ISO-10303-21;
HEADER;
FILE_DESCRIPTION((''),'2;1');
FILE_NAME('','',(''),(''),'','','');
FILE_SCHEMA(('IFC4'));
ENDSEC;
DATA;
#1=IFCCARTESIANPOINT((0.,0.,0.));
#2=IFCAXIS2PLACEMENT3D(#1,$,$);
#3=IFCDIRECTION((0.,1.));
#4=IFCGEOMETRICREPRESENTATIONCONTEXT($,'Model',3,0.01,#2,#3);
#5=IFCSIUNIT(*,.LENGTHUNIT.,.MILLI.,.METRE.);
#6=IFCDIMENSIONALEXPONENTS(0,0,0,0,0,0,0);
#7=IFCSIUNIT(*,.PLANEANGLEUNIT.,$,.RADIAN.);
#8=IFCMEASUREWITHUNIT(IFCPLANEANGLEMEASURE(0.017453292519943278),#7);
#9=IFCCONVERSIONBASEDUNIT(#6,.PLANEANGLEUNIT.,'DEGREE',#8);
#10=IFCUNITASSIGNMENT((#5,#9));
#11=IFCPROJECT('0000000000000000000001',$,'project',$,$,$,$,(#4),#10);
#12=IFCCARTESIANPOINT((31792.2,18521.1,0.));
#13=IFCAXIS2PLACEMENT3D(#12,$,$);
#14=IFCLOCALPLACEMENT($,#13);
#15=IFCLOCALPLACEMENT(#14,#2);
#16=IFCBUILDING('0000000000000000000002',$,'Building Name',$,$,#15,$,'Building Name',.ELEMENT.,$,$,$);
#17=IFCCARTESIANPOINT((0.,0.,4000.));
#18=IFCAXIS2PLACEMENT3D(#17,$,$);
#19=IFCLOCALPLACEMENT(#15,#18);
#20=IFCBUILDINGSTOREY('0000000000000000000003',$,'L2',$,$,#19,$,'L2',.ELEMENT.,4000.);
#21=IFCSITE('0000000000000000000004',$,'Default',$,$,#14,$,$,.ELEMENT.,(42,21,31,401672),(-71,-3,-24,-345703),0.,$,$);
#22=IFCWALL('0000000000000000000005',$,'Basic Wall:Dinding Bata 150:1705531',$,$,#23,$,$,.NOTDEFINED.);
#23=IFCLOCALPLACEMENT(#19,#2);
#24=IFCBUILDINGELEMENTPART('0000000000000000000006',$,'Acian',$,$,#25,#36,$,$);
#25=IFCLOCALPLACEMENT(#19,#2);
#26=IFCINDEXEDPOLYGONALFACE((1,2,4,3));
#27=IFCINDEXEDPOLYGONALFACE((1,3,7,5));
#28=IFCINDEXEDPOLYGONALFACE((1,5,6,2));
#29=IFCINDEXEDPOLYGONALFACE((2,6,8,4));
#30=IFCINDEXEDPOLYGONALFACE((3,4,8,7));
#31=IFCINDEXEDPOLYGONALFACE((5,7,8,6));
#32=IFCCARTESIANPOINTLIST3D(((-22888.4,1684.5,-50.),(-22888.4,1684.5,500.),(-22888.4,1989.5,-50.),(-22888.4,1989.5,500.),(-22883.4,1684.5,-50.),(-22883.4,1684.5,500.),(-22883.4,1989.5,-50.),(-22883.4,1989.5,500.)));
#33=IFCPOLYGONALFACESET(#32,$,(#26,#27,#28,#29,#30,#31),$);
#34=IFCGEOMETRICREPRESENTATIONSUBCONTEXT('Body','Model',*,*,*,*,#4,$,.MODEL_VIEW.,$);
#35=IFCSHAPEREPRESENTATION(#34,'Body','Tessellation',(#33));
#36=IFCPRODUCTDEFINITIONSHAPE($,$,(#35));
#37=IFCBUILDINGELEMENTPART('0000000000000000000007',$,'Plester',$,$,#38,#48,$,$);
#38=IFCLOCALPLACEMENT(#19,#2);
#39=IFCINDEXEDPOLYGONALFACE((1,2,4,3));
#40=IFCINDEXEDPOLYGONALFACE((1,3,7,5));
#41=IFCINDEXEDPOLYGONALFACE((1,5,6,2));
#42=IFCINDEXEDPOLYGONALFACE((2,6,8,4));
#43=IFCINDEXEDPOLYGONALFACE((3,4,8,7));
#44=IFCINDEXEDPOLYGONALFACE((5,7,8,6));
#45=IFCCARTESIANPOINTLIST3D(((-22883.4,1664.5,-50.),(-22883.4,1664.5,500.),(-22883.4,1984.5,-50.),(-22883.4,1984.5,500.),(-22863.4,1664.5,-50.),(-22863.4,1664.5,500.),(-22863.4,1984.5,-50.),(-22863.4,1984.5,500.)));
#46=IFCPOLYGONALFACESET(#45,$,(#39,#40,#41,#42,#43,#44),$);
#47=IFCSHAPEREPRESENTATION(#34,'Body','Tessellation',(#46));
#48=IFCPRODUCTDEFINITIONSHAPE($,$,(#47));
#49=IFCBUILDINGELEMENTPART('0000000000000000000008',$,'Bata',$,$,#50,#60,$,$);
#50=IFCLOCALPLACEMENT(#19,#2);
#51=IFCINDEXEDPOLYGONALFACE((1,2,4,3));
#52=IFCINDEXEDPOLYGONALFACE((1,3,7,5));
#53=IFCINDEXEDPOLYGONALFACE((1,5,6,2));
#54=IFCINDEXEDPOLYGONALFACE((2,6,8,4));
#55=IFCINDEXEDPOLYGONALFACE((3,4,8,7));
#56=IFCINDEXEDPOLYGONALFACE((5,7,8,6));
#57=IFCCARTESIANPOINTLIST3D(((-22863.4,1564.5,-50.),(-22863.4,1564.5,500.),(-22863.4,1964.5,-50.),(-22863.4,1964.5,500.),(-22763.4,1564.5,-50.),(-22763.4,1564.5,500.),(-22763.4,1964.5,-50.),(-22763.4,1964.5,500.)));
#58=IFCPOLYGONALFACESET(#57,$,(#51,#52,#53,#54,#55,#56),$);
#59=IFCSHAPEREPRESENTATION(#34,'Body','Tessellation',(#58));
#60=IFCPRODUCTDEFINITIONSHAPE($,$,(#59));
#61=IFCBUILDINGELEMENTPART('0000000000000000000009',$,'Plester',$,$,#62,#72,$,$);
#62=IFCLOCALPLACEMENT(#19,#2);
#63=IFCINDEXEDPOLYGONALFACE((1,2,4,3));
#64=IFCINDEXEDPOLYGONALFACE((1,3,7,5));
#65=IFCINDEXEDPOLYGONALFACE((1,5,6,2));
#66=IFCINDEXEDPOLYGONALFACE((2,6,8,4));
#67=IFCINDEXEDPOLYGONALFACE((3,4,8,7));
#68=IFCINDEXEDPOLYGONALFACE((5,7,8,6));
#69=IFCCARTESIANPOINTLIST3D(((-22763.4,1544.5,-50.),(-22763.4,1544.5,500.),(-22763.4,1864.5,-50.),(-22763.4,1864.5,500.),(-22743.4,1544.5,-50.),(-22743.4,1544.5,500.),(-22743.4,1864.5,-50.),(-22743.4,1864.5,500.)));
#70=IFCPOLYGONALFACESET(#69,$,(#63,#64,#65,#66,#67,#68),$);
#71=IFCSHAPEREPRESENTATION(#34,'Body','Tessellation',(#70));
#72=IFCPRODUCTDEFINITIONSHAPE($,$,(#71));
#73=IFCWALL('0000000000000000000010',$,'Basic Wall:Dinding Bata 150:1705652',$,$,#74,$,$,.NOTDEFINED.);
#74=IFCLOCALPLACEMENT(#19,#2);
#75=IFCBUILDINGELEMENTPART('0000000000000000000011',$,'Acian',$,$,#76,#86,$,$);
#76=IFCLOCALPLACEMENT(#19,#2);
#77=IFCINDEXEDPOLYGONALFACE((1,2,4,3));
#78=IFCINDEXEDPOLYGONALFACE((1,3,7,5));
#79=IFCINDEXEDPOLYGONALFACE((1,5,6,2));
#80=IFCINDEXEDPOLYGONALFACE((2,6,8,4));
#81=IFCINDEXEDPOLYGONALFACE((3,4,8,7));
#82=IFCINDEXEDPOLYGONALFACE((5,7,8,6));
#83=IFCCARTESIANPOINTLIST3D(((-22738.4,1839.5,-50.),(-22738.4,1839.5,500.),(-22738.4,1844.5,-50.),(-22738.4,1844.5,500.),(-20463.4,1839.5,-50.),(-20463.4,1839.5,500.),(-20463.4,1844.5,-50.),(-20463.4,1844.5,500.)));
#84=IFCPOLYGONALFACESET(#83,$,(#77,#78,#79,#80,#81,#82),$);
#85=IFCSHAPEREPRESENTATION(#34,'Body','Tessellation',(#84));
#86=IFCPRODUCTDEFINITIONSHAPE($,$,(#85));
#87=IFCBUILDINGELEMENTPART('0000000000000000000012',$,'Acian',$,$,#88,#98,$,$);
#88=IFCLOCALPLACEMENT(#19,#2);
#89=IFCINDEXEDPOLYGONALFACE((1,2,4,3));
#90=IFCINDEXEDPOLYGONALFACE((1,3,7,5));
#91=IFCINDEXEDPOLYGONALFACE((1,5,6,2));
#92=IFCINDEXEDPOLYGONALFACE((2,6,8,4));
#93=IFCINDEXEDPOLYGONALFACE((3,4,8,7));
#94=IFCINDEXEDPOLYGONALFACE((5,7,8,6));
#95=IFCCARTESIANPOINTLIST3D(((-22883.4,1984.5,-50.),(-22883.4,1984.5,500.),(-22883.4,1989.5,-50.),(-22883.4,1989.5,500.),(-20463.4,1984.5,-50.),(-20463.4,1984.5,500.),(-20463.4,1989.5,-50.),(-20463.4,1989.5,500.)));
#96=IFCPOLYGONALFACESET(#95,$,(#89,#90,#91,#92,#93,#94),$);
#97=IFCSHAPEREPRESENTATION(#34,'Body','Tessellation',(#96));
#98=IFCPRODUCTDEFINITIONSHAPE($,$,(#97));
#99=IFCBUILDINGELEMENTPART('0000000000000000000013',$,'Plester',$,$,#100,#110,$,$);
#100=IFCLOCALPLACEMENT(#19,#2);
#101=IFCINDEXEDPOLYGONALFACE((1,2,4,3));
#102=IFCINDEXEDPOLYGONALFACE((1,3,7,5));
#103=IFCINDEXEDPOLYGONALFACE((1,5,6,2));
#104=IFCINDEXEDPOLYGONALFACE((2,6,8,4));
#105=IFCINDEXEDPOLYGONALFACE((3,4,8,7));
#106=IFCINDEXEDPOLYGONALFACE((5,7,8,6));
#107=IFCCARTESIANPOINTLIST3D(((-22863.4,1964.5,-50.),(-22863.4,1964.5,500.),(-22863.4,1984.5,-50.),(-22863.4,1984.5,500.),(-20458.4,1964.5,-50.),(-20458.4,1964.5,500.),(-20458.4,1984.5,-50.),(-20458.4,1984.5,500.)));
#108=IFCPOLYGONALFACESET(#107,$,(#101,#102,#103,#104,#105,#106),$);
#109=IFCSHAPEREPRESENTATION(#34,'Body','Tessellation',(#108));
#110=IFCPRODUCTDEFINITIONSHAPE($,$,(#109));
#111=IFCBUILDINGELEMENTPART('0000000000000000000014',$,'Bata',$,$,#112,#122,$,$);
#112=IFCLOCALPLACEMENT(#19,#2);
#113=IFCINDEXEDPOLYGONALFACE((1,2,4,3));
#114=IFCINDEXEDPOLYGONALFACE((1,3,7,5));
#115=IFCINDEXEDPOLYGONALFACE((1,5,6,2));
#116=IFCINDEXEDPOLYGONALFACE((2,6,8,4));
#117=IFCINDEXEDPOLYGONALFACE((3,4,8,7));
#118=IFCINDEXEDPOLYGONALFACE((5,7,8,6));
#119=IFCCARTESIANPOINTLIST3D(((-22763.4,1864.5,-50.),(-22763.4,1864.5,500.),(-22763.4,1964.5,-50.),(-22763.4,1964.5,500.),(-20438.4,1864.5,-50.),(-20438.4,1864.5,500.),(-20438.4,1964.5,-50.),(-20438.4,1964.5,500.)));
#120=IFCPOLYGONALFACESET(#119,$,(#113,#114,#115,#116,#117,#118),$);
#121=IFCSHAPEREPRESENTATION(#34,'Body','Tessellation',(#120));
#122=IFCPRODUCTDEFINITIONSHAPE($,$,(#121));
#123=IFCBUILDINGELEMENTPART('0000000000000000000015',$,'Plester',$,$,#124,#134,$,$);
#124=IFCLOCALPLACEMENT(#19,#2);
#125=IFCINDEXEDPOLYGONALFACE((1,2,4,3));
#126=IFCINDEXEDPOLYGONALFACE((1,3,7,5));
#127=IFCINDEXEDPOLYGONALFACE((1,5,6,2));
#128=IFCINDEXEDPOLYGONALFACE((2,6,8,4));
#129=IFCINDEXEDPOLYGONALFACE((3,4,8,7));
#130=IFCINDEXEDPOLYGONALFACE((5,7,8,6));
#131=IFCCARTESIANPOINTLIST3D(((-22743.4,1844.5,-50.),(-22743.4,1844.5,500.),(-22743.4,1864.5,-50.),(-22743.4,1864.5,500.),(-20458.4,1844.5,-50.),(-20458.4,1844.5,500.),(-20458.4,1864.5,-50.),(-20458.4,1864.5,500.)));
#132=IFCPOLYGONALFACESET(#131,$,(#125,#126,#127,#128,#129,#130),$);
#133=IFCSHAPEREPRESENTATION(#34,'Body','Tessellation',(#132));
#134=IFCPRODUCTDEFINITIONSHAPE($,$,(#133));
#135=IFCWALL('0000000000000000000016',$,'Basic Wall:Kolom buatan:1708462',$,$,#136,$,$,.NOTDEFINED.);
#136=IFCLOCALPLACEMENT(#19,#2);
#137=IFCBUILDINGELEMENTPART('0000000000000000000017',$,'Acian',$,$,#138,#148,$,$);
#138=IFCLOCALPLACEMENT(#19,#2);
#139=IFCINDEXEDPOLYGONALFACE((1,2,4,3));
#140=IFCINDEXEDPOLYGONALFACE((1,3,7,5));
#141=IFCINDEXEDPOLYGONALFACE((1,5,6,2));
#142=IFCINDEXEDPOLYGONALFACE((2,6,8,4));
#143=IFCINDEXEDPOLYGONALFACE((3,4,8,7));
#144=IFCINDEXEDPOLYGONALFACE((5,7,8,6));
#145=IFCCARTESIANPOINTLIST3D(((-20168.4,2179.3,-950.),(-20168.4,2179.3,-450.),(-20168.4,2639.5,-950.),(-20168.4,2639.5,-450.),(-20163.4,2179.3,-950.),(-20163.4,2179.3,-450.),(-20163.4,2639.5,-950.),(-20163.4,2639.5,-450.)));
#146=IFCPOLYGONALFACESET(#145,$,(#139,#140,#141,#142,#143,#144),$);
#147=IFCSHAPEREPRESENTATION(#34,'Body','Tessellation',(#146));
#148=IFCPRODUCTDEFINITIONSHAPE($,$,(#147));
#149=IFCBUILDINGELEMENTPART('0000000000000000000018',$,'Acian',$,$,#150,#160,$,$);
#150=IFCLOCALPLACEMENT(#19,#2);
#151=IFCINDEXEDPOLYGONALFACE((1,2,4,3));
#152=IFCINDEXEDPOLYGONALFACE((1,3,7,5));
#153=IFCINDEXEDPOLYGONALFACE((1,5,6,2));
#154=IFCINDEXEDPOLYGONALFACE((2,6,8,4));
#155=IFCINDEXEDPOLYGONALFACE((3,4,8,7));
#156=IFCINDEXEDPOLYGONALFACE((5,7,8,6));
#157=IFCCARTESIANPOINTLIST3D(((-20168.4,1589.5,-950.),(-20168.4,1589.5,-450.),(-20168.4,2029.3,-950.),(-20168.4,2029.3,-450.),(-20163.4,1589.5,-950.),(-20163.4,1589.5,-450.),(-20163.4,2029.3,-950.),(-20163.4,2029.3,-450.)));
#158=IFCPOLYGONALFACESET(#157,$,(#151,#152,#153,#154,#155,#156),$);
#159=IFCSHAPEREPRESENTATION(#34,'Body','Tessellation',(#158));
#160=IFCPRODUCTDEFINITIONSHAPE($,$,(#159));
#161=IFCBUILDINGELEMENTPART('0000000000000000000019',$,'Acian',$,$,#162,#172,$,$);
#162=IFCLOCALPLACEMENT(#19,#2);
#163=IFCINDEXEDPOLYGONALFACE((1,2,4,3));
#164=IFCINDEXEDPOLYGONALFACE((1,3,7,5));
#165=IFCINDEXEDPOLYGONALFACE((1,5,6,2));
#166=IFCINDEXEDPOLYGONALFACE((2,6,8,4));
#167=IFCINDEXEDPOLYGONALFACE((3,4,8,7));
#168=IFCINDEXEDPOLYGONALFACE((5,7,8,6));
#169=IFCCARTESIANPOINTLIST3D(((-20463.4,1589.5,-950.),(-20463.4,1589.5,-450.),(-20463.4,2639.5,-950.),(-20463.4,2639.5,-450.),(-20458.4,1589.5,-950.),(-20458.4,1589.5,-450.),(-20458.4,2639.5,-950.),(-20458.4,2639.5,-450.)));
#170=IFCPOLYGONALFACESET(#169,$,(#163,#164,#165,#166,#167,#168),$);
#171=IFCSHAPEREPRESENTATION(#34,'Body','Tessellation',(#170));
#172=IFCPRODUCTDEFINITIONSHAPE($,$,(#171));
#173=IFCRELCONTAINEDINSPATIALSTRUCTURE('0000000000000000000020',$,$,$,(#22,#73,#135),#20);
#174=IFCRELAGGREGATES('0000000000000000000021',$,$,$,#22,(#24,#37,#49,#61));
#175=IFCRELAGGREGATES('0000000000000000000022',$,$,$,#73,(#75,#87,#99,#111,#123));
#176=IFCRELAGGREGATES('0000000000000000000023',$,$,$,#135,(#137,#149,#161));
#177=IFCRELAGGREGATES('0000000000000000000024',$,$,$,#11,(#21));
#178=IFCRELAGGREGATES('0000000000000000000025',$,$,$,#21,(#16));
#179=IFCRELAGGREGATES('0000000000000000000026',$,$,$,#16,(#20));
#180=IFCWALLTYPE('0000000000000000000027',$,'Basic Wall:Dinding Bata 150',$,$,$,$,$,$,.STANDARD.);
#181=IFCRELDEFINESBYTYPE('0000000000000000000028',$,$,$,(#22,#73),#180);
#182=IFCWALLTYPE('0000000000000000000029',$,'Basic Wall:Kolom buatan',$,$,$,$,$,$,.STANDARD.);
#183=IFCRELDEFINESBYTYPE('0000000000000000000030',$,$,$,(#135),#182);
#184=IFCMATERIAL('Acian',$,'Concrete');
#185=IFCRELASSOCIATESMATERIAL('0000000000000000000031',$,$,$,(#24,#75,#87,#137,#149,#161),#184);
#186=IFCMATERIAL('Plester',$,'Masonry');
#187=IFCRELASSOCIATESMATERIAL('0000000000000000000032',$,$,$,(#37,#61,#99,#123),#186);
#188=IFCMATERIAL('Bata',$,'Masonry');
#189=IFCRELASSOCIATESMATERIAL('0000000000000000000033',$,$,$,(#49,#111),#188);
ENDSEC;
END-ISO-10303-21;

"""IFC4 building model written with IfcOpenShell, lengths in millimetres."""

from ifc_helpers import new_model, entity, si_unit, converted_unit, direction, frame, origin, place, context, subcontext, project, spatial, indexed_curve, outline, extrude, material, type_object, element, aggregate, save


model = new_model("IFC4")

# Units and contexts
model_context = context("Model", 3, precision=0.01, world=origin(), true_north=direction((0.0, 1.0)))
body_context = subcontext(model_context, "Body", "Model", "MODEL_VIEW")
ifc_project = project(units=[si_unit("LENGTHUNIT", "METRE", prefix="MILLI"), converted_unit("PLANEANGLEUNIT", "DEGREE", entity("IfcPlaneAngleMeasure", 0.017453292519943278), si_unit("PLANEANGLEUNIT", "RADIAN"), dimensions=[0, 0, 0, 0, 0, 0, 0])], contexts=[model_context])

# Site, building, storey
site_placement = place(None, frame((31792.2, 18521.1, 0.0)))
site = spatial("IfcSite", under=ifc_project, at=site_placement, Name="Default", CompositionType="ELEMENT", RefLatitude=(42, 21, 31, 401672), RefLongitude=(-71, -3, -24, -345703), RefElevation=0.0)
building_placement = place(site_placement, origin())
building = spatial("IfcBuilding", under=site, at=building_placement, Name="Building Name", LongName="Building Name", CompositionType="ELEMENT")
storey_placement = place(building_placement, frame((0.0, 0.0, 4000.0)))
storey = spatial("IfcBuildingStorey", under=building, at=storey_placement, Name="L2", LongName="L2", CompositionType="ELEMENT", Elevation=4000.0)

# Walls, building element parts
wall_type_1 = type_object("IfcWallType", Name="Basic Wall:Dinding Bata 150", PredefinedType="STANDARD")
ifc_material_1 = material(Name="Acian", Category="Concrete")
ifc_material_2 = material(Name="Plester", Category="Masonry")
ifc_material_3 = material(Name="Bata", Category="Masonry")
wall_1_placement = place(storey_placement, frame((-22813.4, 1539.5, -50.0), z_axis=(0.0, 0.0, 1.0), x_axis=(0.0, 1.0, 0.0)))
wall_1 = element("IfcWall", 1, at=wall_1_placement, inside=storey, type_object=wall_type_1, Name="Basic Wall:Dinding Bata 150:1705531", PredefinedType="NOTDEFINED")
building_element_part_1_placement = place(wall_1_placement, origin())
building_element_part_1 = element("IfcBuildingElementPart", 2, at=building_element_part_1_placement, material=ifc_material_1, Name="Acian", context=body_context, shape_type="SweptSolid", body=[
    extrude(outline(indexed_curve([(-152.5, -2.5), (152.5, -2.5), (152.5, 2.5), (-152.5, 2.5), (-152.5, -2.5)], self_intersect=False)), frame((297.5, 72.5, 0.0), z_axis=(0.0, 0.0, 1.0), x_axis=(-1.0, 0.0, 0.0)), (0.0, 0.0, 1.0), 550.0),
])
building_element_part_2_placement = place(wall_1_placement, origin())
building_element_part_2 = element("IfcBuildingElementPart", 3, at=building_element_part_2_placement, material=ifc_material_2, Name="Plester", context=body_context, shape_type="SweptSolid", body=[
    extrude(outline(indexed_curve([(-160.0, -10.0), (160.0, -10.0), (160.0, 10.0), (-160.0, 10.0), (-160.0, -10.0)], self_intersect=False)), frame((285.0, 60.0, 0.0), z_axis=(0.0, 0.0, 1.0), x_axis=(-1.0, 0.0, 0.0)), (0.0, 0.0, 1.0), 550.0),
])
building_element_part_3_placement = place(wall_1_placement, origin())
building_element_part_3 = element("IfcBuildingElementPart", 4, at=building_element_part_3_placement, material=ifc_material_3, Name="Bata", context=body_context, shape_type="SweptSolid", body=[
    extrude(outline(indexed_curve([(-200.0, -50.0), (200.0, -50.0), (200.0, 50.0), (-200.0, 50.0), (-200.0, -50.0)], self_intersect=False)), frame((225.0, 0.0, 0.0), z_axis=(0.0, 0.0, 1.0), x_axis=(-1.0, 0.0, 0.0)), (0.0, 0.0, 1.0), 550.0),
])
building_element_part_4_placement = place(wall_1_placement, origin())
building_element_part_4 = element("IfcBuildingElementPart", 5, at=building_element_part_4_placement, material=ifc_material_2, Name="Plester", context=body_context, shape_type="SweptSolid", body=[
    extrude(outline(indexed_curve([(-160.0, -10.0), (160.0, -10.0), (160.0, 10.0), (-160.0, 10.0), (-160.0, -10.0)], self_intersect=False)), frame((165.0, -60.0, 0.0), z_axis=(0.0, 0.0, 1.0), x_axis=(-1.0, 0.0, 0.0)), (0.0, 0.0, 1.0), 550.0),
])
aggregate(wall_1, [building_element_part_1, building_element_part_2, building_element_part_3, building_element_part_4])
wall_2_placement = place(storey_placement, frame((-22738.4, 1914.5, -50.0)))
wall_2 = element("IfcWall", 6, at=wall_2_placement, inside=storey, type_object=wall_type_1, Name="Basic Wall:Dinding Bata 150:1705652", PredefinedType="NOTDEFINED")
building_element_part_5_placement = place(wall_2_placement, origin())
building_element_part_5 = element("IfcBuildingElementPart", 7, at=building_element_part_5_placement, material=ifc_material_1, Name="Acian", context=body_context, shape_type="SweptSolid", body=[
    extrude(outline(indexed_curve([(-2.5, -1137.5), (2.5, -1137.5), (2.5, 1137.5), (-2.5, 1137.5), (-2.5, -1137.5)], self_intersect=False)), frame((1137.5, -72.5, 0.0), z_axis=(0.0, 0.0, 1.0), x_axis=(0.0, -1.0, 0.0)), (0.0, 0.0, 1.0), 550.0),
])
building_element_part_6_placement = place(wall_2_placement, origin())
building_element_part_6 = element("IfcBuildingElementPart", 8, at=building_element_part_6_placement, material=ifc_material_1, Name="Acian", context=body_context, shape_type="SweptSolid", body=[
    extrude(outline(indexed_curve([(-2.5, -1210.0), (2.5, -1210.0), (2.5, 1210.0), (-2.5, 1210.0), (-2.5, -1210.0)], self_intersect=False)), frame((1065.0, 72.5, 0.0), z_axis=(0.0, 0.0, 1.0), x_axis=(0.0, -1.0, 0.0)), (0.0, 0.0, 1.0), 550.0),
])
building_element_part_7_placement = place(wall_2_placement, origin())
building_element_part_7 = element("IfcBuildingElementPart", 9, at=building_element_part_7_placement, material=ifc_material_2, Name="Plester", context=body_context, shape_type="SweptSolid", body=[
    extrude(outline(indexed_curve([(-10.0, -1202.5), (10.0, -1202.5), (10.0, 1202.5), (-10.0, 1202.5), (-10.0, -1202.5)], self_intersect=False)), frame((1077.5, 60.0, 0.0), z_axis=(0.0, 0.0, 1.0), x_axis=(0.0, -1.0, 0.0)), (0.0, 0.0, 1.0), 550.0),
])
building_element_part_8_placement = place(wall_2_placement, origin())
building_element_part_8 = element("IfcBuildingElementPart", 10, at=building_element_part_8_placement, material=ifc_material_3, Name="Bata", context=body_context, shape_type="SweptSolid", body=[
    extrude(outline(indexed_curve([(-50.0, -1162.5), (50.0, -1162.5), (50.0, 1162.5), (-50.0, 1162.5), (-50.0, -1162.5)], self_intersect=False)), frame((1137.5, 0.0, 0.0), z_axis=(0.0, 0.0, 1.0), x_axis=(0.0, -1.0, 0.0)), (0.0, 0.0, 1.0), 550.0),
])
building_element_part_9_placement = place(wall_2_placement, origin())
building_element_part_9 = element("IfcBuildingElementPart", 11, at=building_element_part_9_placement, material=ifc_material_2, Name="Plester", context=body_context, shape_type="SweptSolid", body=[
    extrude(outline(indexed_curve([(-10.0, -1142.5), (10.0, -1142.5), (10.0, 1142.5), (-10.0, 1142.5), (-10.0, -1142.5)], self_intersect=False)), frame((1137.5, -60.0, 0.0), z_axis=(0.0, 0.0, 1.0), x_axis=(0.0, -1.0, 0.0)), (0.0, 0.0, 1.0), 550.0),
])
aggregate(wall_2, [building_element_part_5, building_element_part_6, building_element_part_7, building_element_part_8, building_element_part_9])
wall_type_2 = type_object("IfcWallType", Name="Basic Wall:Kolom buatan", PredefinedType="STANDARD")
wall_3_placement = place(storey_placement, frame((-20313.4, 1589.5, -950.0), z_axis=(0.0, 0.0, 1.0), x_axis=(0.0, 1.0, 0.0)))
wall_3 = element("IfcWall", 12, at=wall_3_placement, inside=storey, type_object=wall_type_2, Name="Basic Wall:Kolom buatan:1708462", PredefinedType="NOTDEFINED")
building_element_part_10_placement = place(wall_3_placement, origin())
building_element_part_10 = element("IfcBuildingElementPart", 13, at=building_element_part_10_placement, material=ifc_material_1, Name="Acian", context=body_context, shape_type="SweptSolid", body=[
    extrude(outline(indexed_curve([(-230.1, -2.5), (230.1, -2.5), (230.1, 2.5), (-230.1, 2.5), (-230.1, -2.5)], self_intersect=False)), frame((819.9, -147.5, 0.0), z_axis=(0.0, 0.0, 1.0), x_axis=(-1.0, 0.0, 0.0)), (0.0, 0.0, 1.0), 500.0),
])
building_element_part_11_placement = place(wall_3_placement, origin())
building_element_part_11 = element("IfcBuildingElementPart", 14, at=building_element_part_11_placement, material=ifc_material_1, Name="Acian", context=body_context, shape_type="SweptSolid", body=[
    extrude(outline(indexed_curve([(-219.9, -2.5), (219.9, -2.5), (219.9, 2.5), (-219.9, 2.5), (-219.9, -2.5)], self_intersect=False)), frame((219.9, -147.5, 0.0), z_axis=(0.0, 0.0, 1.0), x_axis=(-1.0, 0.0, 0.0)), (0.0, 0.0, 1.0), 500.0),
])
building_element_part_12_placement = place(wall_3_placement, origin())
building_element_part_12 = element("IfcBuildingElementPart", 15, at=building_element_part_12_placement, material=ifc_material_1, Name="Acian", context=body_context, shape_type="SweptSolid", body=[
    extrude(outline(indexed_curve([(-525.0, -2.5), (525.0, -2.5), (525.0, 2.5), (-525.0, 2.5), (-525.0, -2.5)], self_intersect=False)), frame((525.0, 147.5, 0.0), z_axis=(0.0, 0.0, 1.0), x_axis=(-1.0, 0.0, 0.0)), (0.0, 0.0, 1.0), 500.0),
])
aggregate(wall_3, [building_element_part_10, building_element_part_11, building_element_part_12])

save(model, "model.ifc")
